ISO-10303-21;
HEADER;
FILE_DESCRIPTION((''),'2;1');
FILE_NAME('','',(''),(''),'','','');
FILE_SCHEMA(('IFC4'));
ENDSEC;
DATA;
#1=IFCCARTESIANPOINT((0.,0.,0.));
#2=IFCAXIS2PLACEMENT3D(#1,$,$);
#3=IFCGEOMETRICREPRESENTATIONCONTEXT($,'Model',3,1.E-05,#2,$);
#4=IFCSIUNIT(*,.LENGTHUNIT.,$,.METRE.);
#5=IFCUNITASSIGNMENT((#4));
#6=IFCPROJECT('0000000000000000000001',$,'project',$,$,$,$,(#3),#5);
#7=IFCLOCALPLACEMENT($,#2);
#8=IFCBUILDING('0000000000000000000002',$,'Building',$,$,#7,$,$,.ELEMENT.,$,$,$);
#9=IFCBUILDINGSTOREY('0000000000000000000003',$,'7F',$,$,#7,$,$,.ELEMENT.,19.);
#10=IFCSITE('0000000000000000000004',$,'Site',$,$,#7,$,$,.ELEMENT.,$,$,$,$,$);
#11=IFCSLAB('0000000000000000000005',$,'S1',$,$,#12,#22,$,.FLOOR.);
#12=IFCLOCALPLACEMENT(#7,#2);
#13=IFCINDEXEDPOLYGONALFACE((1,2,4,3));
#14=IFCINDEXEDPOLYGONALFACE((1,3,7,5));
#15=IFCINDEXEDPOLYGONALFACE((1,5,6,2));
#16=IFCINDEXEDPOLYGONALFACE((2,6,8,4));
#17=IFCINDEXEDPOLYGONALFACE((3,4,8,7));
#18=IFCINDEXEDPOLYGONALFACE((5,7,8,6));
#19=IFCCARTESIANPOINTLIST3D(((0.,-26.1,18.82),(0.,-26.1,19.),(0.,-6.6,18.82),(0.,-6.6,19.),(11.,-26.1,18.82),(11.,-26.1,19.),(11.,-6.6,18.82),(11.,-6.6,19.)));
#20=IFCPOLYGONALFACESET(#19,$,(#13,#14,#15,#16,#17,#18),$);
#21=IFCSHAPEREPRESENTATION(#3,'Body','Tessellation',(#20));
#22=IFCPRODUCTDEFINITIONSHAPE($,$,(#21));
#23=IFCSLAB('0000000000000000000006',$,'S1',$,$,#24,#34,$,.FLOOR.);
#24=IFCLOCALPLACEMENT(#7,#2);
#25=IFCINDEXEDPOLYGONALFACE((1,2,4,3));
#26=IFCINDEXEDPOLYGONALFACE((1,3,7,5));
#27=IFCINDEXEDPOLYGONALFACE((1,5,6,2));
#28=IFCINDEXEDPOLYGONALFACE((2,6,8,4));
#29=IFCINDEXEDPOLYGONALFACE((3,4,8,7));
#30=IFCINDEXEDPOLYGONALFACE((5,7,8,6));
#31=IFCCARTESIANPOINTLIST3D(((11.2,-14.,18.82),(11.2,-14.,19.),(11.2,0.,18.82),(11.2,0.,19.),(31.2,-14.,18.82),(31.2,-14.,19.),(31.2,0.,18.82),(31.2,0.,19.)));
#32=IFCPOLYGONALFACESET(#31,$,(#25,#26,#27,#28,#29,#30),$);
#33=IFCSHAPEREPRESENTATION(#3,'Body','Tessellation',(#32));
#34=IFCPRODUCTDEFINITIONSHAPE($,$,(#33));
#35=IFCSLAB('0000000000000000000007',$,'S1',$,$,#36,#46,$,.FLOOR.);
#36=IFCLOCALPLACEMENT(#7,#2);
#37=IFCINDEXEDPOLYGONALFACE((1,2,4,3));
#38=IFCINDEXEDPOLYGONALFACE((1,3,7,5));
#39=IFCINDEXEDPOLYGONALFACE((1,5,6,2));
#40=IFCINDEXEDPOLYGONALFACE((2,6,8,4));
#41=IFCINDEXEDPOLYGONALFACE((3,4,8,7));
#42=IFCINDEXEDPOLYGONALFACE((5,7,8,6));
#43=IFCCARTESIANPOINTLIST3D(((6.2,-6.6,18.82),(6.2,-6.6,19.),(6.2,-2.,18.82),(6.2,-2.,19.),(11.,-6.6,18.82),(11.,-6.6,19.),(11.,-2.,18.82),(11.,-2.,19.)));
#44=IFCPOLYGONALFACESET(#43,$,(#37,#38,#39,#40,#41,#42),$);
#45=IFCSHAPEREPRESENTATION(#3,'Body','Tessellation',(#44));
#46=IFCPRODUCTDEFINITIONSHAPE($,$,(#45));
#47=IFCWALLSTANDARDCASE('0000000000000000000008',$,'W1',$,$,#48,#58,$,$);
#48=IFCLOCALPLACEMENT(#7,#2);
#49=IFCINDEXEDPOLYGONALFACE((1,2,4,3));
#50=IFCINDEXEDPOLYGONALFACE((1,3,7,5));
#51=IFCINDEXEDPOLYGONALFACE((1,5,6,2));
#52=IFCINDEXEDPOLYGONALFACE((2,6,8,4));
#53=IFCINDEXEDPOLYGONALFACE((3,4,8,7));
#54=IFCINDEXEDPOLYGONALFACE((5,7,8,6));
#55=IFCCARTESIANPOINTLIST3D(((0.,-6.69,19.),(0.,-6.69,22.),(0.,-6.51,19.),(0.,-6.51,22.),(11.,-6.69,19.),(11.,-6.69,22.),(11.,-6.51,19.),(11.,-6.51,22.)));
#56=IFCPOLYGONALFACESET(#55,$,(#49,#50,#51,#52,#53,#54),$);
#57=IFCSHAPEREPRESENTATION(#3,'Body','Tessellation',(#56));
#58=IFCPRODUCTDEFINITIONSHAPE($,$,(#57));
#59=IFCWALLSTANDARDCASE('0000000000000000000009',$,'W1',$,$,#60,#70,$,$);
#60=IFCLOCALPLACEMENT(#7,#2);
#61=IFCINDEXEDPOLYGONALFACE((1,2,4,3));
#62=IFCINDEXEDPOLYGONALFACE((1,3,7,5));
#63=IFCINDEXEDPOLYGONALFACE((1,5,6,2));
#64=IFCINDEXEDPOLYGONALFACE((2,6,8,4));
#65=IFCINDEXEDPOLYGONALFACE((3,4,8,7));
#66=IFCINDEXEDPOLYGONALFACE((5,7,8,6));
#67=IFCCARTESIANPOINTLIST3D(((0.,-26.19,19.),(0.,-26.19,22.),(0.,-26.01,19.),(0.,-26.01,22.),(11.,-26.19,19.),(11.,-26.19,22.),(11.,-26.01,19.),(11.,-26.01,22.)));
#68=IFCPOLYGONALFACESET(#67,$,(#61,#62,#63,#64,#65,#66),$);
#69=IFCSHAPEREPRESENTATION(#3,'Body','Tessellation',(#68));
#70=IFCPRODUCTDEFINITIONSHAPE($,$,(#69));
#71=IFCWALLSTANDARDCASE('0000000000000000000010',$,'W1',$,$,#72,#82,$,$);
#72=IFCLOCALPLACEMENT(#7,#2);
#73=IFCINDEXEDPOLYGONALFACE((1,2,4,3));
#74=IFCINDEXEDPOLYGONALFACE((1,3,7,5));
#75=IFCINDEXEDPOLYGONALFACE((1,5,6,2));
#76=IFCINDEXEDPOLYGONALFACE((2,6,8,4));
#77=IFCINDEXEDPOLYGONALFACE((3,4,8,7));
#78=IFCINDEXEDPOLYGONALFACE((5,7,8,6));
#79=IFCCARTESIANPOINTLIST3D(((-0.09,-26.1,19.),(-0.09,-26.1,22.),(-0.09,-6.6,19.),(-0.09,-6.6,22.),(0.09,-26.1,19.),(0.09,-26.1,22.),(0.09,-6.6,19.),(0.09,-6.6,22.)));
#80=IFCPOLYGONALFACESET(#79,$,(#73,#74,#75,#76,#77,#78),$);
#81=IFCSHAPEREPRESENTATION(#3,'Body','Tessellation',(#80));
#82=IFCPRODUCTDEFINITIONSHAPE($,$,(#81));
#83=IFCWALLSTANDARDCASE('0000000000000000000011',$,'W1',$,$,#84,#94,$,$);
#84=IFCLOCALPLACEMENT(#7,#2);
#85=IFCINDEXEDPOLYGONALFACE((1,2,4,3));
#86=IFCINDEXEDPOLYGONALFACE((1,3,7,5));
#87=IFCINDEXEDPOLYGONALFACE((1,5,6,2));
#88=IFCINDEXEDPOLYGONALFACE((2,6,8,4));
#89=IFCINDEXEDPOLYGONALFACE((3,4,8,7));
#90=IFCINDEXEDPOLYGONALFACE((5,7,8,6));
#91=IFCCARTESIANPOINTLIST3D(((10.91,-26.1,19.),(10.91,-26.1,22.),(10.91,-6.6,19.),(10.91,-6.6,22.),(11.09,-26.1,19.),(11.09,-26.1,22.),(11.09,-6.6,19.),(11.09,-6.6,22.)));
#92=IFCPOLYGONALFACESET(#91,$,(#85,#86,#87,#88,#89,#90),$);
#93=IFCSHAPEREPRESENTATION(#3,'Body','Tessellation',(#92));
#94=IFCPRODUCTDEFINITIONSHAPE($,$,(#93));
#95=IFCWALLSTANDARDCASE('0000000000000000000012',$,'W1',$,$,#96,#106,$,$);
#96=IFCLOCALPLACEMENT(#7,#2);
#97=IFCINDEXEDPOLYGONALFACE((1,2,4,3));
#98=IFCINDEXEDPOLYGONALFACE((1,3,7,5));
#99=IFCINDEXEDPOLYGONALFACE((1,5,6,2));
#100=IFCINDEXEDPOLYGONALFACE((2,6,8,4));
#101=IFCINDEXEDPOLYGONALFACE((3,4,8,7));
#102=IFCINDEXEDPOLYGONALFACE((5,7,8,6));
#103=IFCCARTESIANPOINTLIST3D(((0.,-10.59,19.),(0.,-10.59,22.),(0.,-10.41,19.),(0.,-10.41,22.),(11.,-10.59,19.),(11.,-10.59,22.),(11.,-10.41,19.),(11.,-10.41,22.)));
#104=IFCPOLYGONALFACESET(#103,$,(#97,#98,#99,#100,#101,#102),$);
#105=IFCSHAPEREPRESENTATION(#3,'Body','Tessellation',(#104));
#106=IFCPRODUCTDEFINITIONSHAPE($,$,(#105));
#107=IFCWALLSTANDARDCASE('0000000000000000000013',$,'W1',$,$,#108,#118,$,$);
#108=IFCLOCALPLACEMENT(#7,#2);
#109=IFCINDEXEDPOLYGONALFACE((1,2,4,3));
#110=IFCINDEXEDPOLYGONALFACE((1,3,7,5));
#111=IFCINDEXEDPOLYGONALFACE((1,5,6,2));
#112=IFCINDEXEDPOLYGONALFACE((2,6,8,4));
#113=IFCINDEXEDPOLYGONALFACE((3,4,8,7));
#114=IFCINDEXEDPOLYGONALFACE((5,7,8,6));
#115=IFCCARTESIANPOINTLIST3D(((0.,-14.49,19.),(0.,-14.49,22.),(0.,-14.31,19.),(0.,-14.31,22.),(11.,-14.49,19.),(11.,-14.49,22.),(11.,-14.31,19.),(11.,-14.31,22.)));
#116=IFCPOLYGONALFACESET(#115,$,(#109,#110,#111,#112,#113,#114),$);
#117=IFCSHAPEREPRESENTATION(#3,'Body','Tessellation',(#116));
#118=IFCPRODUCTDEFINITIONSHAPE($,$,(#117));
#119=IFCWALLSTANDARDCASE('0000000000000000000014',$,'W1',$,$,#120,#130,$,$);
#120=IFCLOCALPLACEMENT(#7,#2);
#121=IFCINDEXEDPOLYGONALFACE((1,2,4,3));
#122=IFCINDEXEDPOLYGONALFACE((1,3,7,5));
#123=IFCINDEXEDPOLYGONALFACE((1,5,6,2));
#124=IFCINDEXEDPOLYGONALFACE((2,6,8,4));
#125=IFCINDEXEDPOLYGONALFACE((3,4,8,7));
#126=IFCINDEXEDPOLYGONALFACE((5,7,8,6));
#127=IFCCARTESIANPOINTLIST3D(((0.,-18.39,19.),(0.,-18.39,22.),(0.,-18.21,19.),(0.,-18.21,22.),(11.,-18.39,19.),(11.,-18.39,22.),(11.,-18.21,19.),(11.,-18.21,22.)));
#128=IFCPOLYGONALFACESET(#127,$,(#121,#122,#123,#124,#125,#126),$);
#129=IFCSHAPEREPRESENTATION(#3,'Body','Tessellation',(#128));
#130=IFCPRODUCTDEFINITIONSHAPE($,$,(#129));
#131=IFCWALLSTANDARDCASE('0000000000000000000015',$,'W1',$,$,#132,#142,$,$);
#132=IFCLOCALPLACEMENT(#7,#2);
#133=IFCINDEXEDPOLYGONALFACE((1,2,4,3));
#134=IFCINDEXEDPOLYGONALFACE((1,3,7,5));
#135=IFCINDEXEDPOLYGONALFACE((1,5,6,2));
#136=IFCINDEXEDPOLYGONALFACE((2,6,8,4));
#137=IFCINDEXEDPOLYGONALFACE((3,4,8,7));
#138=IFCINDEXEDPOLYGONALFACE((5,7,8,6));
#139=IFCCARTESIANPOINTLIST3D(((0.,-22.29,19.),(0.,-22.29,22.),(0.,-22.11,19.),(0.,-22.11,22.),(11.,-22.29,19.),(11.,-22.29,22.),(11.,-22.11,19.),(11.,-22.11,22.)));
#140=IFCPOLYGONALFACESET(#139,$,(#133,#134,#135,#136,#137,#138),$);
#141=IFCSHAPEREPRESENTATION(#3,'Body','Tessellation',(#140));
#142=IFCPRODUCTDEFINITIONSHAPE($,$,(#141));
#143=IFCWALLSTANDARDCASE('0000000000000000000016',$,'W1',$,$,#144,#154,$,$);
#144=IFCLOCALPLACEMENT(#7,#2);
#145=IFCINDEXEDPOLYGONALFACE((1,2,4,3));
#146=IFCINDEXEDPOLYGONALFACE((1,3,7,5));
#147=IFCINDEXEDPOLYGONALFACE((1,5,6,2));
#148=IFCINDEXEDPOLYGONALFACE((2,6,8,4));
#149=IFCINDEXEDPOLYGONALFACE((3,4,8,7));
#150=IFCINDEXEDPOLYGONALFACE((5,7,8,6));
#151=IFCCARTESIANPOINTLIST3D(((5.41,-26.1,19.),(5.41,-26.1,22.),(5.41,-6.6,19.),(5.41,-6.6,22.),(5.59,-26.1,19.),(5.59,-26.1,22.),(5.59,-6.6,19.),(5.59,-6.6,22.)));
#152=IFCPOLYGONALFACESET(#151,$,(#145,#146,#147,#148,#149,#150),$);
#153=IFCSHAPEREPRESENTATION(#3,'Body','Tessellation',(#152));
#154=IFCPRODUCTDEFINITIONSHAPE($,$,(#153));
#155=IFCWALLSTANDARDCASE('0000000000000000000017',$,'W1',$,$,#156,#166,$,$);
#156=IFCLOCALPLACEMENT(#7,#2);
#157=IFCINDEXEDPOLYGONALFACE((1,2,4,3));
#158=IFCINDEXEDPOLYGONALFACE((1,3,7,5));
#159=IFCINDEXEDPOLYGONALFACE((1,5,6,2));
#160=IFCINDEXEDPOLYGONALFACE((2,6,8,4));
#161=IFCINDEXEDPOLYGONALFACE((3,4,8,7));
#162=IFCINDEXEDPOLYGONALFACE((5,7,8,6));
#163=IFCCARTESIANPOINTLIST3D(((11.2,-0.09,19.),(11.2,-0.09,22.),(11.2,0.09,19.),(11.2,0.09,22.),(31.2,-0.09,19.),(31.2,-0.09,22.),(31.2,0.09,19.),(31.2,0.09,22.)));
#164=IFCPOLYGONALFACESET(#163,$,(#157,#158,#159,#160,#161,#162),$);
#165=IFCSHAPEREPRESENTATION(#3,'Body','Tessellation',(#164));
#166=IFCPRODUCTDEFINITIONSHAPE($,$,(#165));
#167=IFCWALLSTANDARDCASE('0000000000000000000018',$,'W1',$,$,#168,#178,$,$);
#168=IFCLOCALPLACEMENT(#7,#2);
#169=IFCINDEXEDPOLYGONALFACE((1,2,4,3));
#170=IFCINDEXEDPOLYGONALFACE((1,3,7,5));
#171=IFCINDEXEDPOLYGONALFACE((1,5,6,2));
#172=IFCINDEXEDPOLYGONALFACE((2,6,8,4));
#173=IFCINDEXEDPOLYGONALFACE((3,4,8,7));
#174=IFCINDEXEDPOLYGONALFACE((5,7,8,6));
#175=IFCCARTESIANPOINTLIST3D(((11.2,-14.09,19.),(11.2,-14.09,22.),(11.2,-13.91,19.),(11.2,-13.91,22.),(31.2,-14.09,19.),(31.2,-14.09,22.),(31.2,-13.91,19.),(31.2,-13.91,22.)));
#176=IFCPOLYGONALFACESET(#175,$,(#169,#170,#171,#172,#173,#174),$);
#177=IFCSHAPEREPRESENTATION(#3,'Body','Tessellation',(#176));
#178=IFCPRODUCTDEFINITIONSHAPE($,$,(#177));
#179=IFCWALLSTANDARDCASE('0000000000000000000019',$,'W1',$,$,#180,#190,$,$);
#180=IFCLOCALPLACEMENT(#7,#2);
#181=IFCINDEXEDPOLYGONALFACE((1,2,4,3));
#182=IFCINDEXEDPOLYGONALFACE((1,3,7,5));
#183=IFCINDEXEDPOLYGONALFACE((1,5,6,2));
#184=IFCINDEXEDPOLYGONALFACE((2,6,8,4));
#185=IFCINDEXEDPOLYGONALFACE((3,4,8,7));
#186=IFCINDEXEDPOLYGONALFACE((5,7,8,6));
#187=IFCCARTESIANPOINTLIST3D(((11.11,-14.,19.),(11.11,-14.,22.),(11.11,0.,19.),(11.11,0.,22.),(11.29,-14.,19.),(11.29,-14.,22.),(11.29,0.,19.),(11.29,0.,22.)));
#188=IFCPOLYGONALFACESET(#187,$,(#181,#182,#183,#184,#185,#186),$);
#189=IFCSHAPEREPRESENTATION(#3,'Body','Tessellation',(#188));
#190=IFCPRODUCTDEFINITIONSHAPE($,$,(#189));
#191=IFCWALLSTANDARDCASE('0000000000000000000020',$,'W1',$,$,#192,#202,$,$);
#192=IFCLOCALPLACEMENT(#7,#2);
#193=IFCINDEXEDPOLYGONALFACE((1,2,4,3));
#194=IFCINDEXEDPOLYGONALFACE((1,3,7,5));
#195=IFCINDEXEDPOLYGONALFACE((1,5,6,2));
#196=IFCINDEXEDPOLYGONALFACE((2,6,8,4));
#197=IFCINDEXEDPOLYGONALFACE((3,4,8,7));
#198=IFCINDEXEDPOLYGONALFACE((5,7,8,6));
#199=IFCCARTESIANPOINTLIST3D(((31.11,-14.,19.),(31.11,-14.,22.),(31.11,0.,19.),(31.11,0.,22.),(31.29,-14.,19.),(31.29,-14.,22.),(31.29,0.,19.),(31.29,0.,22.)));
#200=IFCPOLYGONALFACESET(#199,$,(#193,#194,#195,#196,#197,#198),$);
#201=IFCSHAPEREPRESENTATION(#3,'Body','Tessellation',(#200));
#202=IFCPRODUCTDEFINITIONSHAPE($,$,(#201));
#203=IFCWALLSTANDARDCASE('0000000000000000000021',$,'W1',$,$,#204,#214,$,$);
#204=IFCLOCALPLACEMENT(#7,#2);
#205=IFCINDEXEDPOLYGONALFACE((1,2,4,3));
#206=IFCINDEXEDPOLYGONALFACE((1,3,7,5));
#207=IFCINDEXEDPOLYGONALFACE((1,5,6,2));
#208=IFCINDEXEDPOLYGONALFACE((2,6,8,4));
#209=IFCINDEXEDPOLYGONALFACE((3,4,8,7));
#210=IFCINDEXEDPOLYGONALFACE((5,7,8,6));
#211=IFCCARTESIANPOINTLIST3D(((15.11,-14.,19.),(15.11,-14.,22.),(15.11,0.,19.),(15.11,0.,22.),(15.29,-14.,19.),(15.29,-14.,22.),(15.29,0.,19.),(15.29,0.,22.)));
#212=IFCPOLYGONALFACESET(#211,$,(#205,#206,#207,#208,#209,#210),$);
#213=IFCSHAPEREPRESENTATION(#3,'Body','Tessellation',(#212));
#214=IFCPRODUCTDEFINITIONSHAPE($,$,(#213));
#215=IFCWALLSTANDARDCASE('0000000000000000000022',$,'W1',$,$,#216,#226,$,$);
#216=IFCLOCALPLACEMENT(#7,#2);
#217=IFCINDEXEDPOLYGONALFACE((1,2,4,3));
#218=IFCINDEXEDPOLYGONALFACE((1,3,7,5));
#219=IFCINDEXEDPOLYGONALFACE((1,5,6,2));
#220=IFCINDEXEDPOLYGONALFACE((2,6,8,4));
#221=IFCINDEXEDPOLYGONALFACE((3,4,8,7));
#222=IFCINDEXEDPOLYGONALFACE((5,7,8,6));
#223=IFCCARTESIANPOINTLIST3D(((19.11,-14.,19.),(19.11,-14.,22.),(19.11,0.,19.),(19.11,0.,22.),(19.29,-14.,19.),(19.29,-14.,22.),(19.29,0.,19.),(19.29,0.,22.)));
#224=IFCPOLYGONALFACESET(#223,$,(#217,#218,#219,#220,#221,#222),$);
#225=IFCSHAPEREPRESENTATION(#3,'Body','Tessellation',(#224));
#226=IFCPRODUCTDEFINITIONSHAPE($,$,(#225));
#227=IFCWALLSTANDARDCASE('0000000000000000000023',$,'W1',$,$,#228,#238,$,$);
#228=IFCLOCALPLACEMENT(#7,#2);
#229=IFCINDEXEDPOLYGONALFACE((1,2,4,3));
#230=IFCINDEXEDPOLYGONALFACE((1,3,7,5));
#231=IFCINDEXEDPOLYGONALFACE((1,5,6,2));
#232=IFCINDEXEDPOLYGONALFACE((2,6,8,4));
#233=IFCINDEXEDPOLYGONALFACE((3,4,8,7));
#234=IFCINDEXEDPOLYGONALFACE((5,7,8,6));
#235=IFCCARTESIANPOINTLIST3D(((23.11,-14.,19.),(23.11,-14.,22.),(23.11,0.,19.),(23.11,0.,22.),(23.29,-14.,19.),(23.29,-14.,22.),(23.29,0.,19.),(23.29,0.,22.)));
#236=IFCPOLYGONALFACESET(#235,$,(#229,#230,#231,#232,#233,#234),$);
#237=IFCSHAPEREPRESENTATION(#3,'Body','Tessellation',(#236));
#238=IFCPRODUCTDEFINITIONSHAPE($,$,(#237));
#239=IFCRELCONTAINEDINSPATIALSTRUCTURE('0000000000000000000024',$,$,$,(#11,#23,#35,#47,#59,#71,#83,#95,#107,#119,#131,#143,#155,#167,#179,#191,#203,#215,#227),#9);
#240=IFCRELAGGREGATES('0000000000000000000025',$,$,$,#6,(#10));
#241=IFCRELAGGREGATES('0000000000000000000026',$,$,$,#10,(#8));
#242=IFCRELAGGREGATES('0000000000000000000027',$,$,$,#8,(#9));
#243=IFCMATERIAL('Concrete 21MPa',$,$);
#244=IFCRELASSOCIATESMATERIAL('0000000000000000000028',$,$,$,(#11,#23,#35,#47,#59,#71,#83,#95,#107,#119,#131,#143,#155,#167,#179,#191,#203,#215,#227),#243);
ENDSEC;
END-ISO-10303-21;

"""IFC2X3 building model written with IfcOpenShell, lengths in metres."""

from ifc_helpers import new_model, si_unit, frame, origin, origin_2d, place, context, project, spatial, rectangle, extrude, material, element, save


model = new_model("IFC2X3")

# Units and contexts
model_context = context("Model", 3, precision=1e-05, world=origin())
ifc_project = project(units=[si_unit("LENGTHUNIT", "METRE")], contexts=[model_context])

# Site, building, storey
placement = place(None, origin())
site = spatial("IfcSite", under=ifc_project, at=placement, Name="Site", CompositionType="ELEMENT")
building = spatial("IfcBuilding", under=site, at=placement, Name="Building", CompositionType="ELEMENT")
storey = spatial("IfcBuildingStorey", under=building, at=placement, Name="7F", CompositionType="ELEMENT", Elevation=19.0)

# Slabs
ifc_material_1 = material(Name="Concrete 21MPa")
slab_1_placement = place(None, frame((5.5, -16.35, 18.82)))
element("IfcSlab", 1, at=slab_1_placement, inside=storey, material=ifc_material_1, Name="S1", PredefinedType="FLOOR", context=model_context, shape_type="SweptSolid", body=[
    extrude(rectangle(XDim=11.0, YDim=19.5, at=origin_2d()), origin(), (0.0, 0.0, 1.0), 0.18),
])
slab_2_placement = place(None, frame((21.2, -7.0, 18.82)))
element("IfcSlab", 2, at=slab_2_placement, inside=storey, material=ifc_material_1, Name="S1", PredefinedType="FLOOR", context=model_context, shape_type="SweptSolid", body=[
    extrude(rectangle(XDim=20.0, YDim=14.0, at=origin_2d()), origin(), (0.0, 0.0, 1.0), 0.18),
])
slab_3_placement = place(None, frame((8.6, -4.3, 18.82)))
element("IfcSlab", 3, at=slab_3_placement, inside=storey, material=ifc_material_1, Name="S1", PredefinedType="FLOOR", context=model_context, shape_type="SweptSolid", body=[
    extrude(rectangle(XDim=4.8, YDim=4.6, at=origin_2d()), origin(), (0.0, 0.0, 1.0), 0.18),
])

# Walls
for number, where, name in (
    (4, (5.5, -6.6, 19.0), "W1"),
    (5, (5.5, -26.1, 19.0), "W1"),
):
    element("IfcWallStandardCase", number, at=place(None, frame(where)), inside=storey, material=ifc_material_1, Name=name, context=model_context, shape_type="SweptSolid", body=[
        extrude(rectangle(XDim=11.0, YDim=0.18, at=origin_2d()), origin(), (0.0, 0.0, 1.0), 3.0),
    ])
for number, where, name in (
    (6, (0.0, -16.35, 19.0), "W1"),
    (7, (11.0, -16.35, 19.0), "W1"),
):
    element("IfcWallStandardCase", number, at=place(None, frame(where)), inside=storey, material=ifc_material_1, Name=name, context=model_context, shape_type="SweptSolid", body=[
        extrude(rectangle(XDim=0.18, YDim=19.5, at=origin_2d()), origin(), (0.0, 0.0, 1.0), 3.0),
    ])
for number, where, name in (
    (8, (5.5, -10.5, 19.0), "W1"),
    (9, (5.5, -14.4, 19.0), "W1"),
    (10, (5.5, -18.3, 19.0), "W1"),
    (11, (5.5, -22.2, 19.0), "W1"),
):
    element("IfcWallStandardCase", number, at=place(None, frame(where)), inside=storey, material=ifc_material_1, Name=name, context=model_context, shape_type="SweptSolid", body=[
        extrude(rectangle(XDim=11.0, YDim=0.18, at=origin_2d()), origin(), (0.0, 0.0, 1.0), 3.0),
    ])
wall_1_placement = place(None, frame((5.5, -16.35, 19.0)))
element("IfcWallStandardCase", 12, at=wall_1_placement, inside=storey, material=ifc_material_1, Name="W1", context=model_context, shape_type="SweptSolid", body=[
    extrude(rectangle(XDim=0.18, YDim=19.5, at=origin_2d()), origin(), (0.0, 0.0, 1.0), 3.0),
])
for number, where, name in (
    (13, (21.2, 0.0, 19.0), "W1"),
    (14, (21.2, -14.0, 19.0), "W1"),
):
    element("IfcWallStandardCase", number, at=place(None, frame(where)), inside=storey, material=ifc_material_1, Name=name, context=model_context, shape_type="SweptSolid", body=[
        extrude(rectangle(XDim=20.0, YDim=0.18, at=origin_2d()), origin(), (0.0, 0.0, 1.0), 3.0),
    ])
for number, where, name in (
    (15, (11.2, -7.0, 19.0), "W1"),
    (16, (31.2, -7.0, 19.0), "W1"),
    (17, (15.2, -7.0, 19.0), "W1"),
    (18, (19.2, -7.0, 19.0), "W1"),
    (19, (23.2, -7.0, 19.0), "W1"),
):
    element("IfcWallStandardCase", number, at=place(None, frame(where)), inside=storey, material=ifc_material_1, Name=name, context=model_context, shape_type="SweptSolid", body=[
        extrude(rectangle(XDim=0.18, YDim=14.0, at=origin_2d()), origin(), (0.0, 0.0, 1.0), 3.0),
    ])

save(model, "model.ifc")
